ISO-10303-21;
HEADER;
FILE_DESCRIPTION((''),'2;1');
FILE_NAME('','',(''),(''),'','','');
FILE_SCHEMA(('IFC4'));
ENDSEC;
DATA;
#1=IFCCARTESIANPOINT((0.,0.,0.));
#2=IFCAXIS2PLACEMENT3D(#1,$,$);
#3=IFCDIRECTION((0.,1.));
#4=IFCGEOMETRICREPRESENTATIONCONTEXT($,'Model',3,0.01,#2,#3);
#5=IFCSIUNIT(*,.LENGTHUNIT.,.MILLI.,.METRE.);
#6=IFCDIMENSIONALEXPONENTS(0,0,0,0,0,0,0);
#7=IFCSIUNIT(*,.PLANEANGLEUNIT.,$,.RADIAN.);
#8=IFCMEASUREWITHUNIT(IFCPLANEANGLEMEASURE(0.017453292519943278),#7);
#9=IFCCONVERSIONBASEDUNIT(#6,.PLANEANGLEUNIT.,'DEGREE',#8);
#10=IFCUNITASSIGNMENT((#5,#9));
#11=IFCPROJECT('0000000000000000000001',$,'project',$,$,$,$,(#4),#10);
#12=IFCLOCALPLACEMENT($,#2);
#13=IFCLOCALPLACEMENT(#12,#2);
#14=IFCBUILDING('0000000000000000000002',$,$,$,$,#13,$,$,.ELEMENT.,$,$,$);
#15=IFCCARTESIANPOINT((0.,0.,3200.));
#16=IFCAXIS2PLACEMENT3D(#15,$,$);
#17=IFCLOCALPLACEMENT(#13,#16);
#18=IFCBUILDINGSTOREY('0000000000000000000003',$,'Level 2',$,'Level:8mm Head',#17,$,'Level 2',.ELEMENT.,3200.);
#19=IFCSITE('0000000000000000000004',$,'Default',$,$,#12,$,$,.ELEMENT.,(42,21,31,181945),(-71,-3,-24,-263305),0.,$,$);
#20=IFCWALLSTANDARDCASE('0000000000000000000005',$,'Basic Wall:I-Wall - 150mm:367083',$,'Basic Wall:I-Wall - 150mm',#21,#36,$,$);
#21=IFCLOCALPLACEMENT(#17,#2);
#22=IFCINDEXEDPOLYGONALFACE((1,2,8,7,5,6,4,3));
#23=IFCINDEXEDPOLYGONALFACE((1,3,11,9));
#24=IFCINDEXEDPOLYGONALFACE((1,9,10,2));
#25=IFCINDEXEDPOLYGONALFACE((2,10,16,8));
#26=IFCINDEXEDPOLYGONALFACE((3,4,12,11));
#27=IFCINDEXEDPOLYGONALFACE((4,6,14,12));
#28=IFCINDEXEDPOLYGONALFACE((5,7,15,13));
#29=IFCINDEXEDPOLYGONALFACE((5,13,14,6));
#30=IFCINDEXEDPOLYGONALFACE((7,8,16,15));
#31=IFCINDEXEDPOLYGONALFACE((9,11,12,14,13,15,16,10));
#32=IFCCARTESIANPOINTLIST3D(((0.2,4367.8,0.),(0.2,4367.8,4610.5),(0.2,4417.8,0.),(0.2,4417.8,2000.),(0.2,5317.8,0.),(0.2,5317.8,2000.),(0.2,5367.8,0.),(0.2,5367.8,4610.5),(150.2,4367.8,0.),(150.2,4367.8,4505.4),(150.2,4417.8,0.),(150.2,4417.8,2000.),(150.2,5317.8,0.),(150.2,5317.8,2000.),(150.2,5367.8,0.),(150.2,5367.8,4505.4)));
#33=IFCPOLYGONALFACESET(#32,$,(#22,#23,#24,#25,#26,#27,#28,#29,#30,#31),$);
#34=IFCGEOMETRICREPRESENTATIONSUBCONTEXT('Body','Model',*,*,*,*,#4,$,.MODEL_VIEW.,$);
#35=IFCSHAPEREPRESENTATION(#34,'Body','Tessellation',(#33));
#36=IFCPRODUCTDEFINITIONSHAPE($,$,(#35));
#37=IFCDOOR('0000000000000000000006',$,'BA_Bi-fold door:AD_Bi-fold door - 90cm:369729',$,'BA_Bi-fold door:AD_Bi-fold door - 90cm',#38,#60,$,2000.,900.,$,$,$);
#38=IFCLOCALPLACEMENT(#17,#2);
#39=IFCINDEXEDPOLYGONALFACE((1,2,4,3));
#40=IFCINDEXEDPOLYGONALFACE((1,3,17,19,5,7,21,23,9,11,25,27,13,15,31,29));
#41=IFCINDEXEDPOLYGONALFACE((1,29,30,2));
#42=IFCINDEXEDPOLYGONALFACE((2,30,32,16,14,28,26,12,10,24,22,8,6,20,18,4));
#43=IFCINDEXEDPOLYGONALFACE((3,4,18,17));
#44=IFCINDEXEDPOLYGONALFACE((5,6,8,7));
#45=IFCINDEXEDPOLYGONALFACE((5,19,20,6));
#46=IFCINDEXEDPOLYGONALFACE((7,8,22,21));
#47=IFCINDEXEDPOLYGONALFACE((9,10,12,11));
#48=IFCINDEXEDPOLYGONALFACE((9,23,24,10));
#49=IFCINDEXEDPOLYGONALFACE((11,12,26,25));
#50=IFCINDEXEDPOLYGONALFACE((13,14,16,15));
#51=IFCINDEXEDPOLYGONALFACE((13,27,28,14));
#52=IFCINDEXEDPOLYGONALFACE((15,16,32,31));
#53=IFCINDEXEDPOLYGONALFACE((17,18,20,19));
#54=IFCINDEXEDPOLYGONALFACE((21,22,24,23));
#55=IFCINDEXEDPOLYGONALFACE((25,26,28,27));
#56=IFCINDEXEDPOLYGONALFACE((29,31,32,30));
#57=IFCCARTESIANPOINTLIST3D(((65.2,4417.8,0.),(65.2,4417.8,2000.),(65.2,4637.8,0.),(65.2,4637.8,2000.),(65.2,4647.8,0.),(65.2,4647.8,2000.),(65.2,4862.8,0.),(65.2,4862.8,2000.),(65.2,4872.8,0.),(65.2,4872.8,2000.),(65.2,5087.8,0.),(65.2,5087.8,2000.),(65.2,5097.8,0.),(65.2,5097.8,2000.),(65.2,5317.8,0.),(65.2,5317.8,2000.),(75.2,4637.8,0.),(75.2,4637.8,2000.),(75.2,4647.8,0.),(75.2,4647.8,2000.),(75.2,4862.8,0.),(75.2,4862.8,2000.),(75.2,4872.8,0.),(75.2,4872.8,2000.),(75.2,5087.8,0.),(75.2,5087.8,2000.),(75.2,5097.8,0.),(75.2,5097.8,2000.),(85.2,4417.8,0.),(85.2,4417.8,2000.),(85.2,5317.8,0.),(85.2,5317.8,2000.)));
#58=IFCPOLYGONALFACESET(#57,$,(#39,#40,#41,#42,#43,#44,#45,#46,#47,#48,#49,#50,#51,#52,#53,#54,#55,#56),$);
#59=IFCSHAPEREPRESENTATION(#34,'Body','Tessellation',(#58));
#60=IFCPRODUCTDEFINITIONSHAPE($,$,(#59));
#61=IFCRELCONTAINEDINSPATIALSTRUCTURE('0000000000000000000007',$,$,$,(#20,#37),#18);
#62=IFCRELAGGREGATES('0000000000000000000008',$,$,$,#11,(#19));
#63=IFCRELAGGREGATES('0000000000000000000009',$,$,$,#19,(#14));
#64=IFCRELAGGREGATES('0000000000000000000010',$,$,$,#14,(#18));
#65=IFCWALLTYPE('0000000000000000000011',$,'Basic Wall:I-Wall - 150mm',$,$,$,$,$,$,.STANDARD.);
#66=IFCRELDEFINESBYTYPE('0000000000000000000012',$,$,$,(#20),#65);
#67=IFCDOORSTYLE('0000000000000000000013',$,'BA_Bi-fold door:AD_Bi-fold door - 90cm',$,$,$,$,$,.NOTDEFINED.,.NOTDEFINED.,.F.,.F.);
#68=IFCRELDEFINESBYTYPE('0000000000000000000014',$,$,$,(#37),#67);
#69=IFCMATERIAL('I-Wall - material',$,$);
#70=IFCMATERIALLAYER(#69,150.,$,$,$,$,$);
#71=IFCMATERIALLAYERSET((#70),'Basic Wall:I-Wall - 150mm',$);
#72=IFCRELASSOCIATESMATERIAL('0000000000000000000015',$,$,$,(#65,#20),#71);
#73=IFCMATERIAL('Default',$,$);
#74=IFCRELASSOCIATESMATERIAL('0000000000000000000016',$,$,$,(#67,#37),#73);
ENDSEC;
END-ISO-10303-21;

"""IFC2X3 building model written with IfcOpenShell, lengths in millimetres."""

from ifc_helpers import new_model, entity, si_unit, converted_unit, direction, frame, frame_2d, origin, place, context, subcontext, project, spatial, polyline, rectangle, outline, extrude, clip, bounded_halfspace, source, transform, mapped, material, layer, layer_set, layer_usage, type_object, type_shapes, element, fill, save


model = new_model("IFC2X3")

# Units and contexts
model_context = context("Model", 3, precision=0.01, world=origin(), true_north=direction((0.0, 1.0)))
body_context = subcontext(model_context, "Body", "Model", "MODEL_VIEW")
ifc_project = project(units=[si_unit("LENGTHUNIT", "METRE", prefix="MILLI"), converted_unit("PLANEANGLEUNIT", "DEGREE", entity("IfcPlaneAngleMeasure", 0.017453292519943278), si_unit("PLANEANGLEUNIT", "RADIAN"), dimensions=[0, 0, 0, 0, 0, 0, 0])], contexts=[model_context])

# Site, building, storey
site_placement = place(None, origin())
site = spatial("IfcSite", under=ifc_project, at=site_placement, Name="Default", CompositionType="ELEMENT", RefLatitude=(42, 21, 31, 181945), RefLongitude=(-71, -3, -24, -263305), RefElevation=0.0)
building_placement = place(site_placement, origin())
building = spatial("IfcBuilding", under=site, at=building_placement, CompositionType="ELEMENT")
storey_placement = place(building_placement, frame((0.0, 0.0, 3200.0)))
storey = spatial("IfcBuildingStorey", under=building, at=storey_placement, Name="Level 2", ObjectType="Level:8mm Head", LongName="Level 2", CompositionType="ELEMENT", Elevation=3200.0)

# Wall, opening, door
ifc_material_1 = material(Name="I-Wall - material")
ifc_layer = layer(ifc_material_1, 150.0)
ifc_layer_set = layer_set([ifc_layer], Name="Basic Wall:I-Wall - 150mm")
ifc_layer_usage = layer_usage(ifc_layer_set, "AXIS2", "NEGATIVE", 75.0)
wall_type = type_object("IfcWallType", Name="Basic Wall:I-Wall - 150mm", PredefinedType="STANDARD", material=ifc_layer_set)
wall_placement = place(storey_placement, frame((75.2, 5367.8, 0.0), z_axis=(0.0, 0.0, 1.0), x_axis=(0.0, -1.0, 0.0)))
wall = element("IfcWallStandardCase", 1, at=wall_placement, inside=storey, type_object=wall_type, material=ifc_layer_usage, Name="Basic Wall:I-Wall - 150mm:367083", ObjectType="Basic Wall:I-Wall - 150mm", context=body_context, shape_type="Clipping", body=[
    clip(extrude(rectangle(XDim=1000.0, YDim=150.0, at=frame_2d((500.0, 0.0), x_axis=(1.0, 0.0))), origin(), (0.0, 0.0, 1.0), 4610.5), bounded_halfspace(frame((0.0, -75.0, 4610.5), z_axis=(0.0, 0.573576, 0.819152), x_axis=(-1.0, 0.0, 0.0)), False, frame((0.0, -75.0, 4610.5)), polyline([(0.0, 0.0), (1000.0, 0.0), (1000.0, 150.0), (0.0, 150.0), (0.0, 0.0)]))),
])
opening_placement = place(wall_placement, frame((950.0, 75.0, 0.0)))
opening = element("IfcOpeningElement", 2, at=opening_placement, cuts=wall, ObjectType="Opening", context=body_context, shape_type="SweptSolid", body=[
    extrude(rectangle(XDim=2000.0, YDim=900.0, at=frame_2d((1000.0, 450.0), x_axis=(1.0, 0.0))), frame((0.0, 0.0, 0.0), z_axis=(0.0, -1.0, 0.0), x_axis=(0.0, 0.0, 1.0)), (0.0, 0.0, 1.0), 150.0),
])
ifc_material_2 = material(Name="Default")
door_style = type_object("IfcDoorStyle", Name="BA_Bi-fold door:AD_Bi-fold door - 90cm", ConstructionType="NOTDEFINED", OperationType="NOTDEFINED", ParameterTakesPrecedence=False, Sizeable=False, material=ifc_material_2)
shared_shape_1 = source(origin(), body_context, "Body", "SweptSolid", [
    extrude(outline(polyline([(-6.2, -230.0), (-6.2, -450.0), (13.8, -450.0), (13.8, 450.0), (-6.2, 450.0), (-6.2, 230.0), (3.8, 230.0), (3.8, 220.0), (-6.2, 220.0), (-6.2, 5.0), (3.8, 5.0), (3.8, -5.0), (-6.2, -5.0), (-6.2, -220.0), (3.8, -220.0), (3.8, -230.0), (-6.2, -230.0)])), frame((450.0, 78.7, 0.0), z_axis=(0.0, 0.0, -1.0), x_axis=(0.0, -1.0, 0.0)), (0.0, 0.0, -1.0), 2000.0),
])
type_shapes(door_style, [shared_shape_1])
door_placement = place(opening_placement, frame((0.0, 0.0, 0.0), z_axis=(0.0, 0.0, 1.0), x_axis=(-1.0, 0.0, 0.0)))
door = element("IfcDoor", 3, at=door_placement, inside=storey, type_object=door_style, material=ifc_material_2, Name="BA_Bi-fold door:AD_Bi-fold door - 90cm:369729", ObjectType="BA_Bi-fold door:AD_Bi-fold door - 90cm", OverallHeight=2000.0, OverallWidth=900.0, context=body_context, shape_type="MappedRepresentation", body=[
    mapped(shared_shape_1, transform((0.0, 0.0, 0.0), scale=1.0)),
])
fill(opening, door)

save(model, "model.ifc")
